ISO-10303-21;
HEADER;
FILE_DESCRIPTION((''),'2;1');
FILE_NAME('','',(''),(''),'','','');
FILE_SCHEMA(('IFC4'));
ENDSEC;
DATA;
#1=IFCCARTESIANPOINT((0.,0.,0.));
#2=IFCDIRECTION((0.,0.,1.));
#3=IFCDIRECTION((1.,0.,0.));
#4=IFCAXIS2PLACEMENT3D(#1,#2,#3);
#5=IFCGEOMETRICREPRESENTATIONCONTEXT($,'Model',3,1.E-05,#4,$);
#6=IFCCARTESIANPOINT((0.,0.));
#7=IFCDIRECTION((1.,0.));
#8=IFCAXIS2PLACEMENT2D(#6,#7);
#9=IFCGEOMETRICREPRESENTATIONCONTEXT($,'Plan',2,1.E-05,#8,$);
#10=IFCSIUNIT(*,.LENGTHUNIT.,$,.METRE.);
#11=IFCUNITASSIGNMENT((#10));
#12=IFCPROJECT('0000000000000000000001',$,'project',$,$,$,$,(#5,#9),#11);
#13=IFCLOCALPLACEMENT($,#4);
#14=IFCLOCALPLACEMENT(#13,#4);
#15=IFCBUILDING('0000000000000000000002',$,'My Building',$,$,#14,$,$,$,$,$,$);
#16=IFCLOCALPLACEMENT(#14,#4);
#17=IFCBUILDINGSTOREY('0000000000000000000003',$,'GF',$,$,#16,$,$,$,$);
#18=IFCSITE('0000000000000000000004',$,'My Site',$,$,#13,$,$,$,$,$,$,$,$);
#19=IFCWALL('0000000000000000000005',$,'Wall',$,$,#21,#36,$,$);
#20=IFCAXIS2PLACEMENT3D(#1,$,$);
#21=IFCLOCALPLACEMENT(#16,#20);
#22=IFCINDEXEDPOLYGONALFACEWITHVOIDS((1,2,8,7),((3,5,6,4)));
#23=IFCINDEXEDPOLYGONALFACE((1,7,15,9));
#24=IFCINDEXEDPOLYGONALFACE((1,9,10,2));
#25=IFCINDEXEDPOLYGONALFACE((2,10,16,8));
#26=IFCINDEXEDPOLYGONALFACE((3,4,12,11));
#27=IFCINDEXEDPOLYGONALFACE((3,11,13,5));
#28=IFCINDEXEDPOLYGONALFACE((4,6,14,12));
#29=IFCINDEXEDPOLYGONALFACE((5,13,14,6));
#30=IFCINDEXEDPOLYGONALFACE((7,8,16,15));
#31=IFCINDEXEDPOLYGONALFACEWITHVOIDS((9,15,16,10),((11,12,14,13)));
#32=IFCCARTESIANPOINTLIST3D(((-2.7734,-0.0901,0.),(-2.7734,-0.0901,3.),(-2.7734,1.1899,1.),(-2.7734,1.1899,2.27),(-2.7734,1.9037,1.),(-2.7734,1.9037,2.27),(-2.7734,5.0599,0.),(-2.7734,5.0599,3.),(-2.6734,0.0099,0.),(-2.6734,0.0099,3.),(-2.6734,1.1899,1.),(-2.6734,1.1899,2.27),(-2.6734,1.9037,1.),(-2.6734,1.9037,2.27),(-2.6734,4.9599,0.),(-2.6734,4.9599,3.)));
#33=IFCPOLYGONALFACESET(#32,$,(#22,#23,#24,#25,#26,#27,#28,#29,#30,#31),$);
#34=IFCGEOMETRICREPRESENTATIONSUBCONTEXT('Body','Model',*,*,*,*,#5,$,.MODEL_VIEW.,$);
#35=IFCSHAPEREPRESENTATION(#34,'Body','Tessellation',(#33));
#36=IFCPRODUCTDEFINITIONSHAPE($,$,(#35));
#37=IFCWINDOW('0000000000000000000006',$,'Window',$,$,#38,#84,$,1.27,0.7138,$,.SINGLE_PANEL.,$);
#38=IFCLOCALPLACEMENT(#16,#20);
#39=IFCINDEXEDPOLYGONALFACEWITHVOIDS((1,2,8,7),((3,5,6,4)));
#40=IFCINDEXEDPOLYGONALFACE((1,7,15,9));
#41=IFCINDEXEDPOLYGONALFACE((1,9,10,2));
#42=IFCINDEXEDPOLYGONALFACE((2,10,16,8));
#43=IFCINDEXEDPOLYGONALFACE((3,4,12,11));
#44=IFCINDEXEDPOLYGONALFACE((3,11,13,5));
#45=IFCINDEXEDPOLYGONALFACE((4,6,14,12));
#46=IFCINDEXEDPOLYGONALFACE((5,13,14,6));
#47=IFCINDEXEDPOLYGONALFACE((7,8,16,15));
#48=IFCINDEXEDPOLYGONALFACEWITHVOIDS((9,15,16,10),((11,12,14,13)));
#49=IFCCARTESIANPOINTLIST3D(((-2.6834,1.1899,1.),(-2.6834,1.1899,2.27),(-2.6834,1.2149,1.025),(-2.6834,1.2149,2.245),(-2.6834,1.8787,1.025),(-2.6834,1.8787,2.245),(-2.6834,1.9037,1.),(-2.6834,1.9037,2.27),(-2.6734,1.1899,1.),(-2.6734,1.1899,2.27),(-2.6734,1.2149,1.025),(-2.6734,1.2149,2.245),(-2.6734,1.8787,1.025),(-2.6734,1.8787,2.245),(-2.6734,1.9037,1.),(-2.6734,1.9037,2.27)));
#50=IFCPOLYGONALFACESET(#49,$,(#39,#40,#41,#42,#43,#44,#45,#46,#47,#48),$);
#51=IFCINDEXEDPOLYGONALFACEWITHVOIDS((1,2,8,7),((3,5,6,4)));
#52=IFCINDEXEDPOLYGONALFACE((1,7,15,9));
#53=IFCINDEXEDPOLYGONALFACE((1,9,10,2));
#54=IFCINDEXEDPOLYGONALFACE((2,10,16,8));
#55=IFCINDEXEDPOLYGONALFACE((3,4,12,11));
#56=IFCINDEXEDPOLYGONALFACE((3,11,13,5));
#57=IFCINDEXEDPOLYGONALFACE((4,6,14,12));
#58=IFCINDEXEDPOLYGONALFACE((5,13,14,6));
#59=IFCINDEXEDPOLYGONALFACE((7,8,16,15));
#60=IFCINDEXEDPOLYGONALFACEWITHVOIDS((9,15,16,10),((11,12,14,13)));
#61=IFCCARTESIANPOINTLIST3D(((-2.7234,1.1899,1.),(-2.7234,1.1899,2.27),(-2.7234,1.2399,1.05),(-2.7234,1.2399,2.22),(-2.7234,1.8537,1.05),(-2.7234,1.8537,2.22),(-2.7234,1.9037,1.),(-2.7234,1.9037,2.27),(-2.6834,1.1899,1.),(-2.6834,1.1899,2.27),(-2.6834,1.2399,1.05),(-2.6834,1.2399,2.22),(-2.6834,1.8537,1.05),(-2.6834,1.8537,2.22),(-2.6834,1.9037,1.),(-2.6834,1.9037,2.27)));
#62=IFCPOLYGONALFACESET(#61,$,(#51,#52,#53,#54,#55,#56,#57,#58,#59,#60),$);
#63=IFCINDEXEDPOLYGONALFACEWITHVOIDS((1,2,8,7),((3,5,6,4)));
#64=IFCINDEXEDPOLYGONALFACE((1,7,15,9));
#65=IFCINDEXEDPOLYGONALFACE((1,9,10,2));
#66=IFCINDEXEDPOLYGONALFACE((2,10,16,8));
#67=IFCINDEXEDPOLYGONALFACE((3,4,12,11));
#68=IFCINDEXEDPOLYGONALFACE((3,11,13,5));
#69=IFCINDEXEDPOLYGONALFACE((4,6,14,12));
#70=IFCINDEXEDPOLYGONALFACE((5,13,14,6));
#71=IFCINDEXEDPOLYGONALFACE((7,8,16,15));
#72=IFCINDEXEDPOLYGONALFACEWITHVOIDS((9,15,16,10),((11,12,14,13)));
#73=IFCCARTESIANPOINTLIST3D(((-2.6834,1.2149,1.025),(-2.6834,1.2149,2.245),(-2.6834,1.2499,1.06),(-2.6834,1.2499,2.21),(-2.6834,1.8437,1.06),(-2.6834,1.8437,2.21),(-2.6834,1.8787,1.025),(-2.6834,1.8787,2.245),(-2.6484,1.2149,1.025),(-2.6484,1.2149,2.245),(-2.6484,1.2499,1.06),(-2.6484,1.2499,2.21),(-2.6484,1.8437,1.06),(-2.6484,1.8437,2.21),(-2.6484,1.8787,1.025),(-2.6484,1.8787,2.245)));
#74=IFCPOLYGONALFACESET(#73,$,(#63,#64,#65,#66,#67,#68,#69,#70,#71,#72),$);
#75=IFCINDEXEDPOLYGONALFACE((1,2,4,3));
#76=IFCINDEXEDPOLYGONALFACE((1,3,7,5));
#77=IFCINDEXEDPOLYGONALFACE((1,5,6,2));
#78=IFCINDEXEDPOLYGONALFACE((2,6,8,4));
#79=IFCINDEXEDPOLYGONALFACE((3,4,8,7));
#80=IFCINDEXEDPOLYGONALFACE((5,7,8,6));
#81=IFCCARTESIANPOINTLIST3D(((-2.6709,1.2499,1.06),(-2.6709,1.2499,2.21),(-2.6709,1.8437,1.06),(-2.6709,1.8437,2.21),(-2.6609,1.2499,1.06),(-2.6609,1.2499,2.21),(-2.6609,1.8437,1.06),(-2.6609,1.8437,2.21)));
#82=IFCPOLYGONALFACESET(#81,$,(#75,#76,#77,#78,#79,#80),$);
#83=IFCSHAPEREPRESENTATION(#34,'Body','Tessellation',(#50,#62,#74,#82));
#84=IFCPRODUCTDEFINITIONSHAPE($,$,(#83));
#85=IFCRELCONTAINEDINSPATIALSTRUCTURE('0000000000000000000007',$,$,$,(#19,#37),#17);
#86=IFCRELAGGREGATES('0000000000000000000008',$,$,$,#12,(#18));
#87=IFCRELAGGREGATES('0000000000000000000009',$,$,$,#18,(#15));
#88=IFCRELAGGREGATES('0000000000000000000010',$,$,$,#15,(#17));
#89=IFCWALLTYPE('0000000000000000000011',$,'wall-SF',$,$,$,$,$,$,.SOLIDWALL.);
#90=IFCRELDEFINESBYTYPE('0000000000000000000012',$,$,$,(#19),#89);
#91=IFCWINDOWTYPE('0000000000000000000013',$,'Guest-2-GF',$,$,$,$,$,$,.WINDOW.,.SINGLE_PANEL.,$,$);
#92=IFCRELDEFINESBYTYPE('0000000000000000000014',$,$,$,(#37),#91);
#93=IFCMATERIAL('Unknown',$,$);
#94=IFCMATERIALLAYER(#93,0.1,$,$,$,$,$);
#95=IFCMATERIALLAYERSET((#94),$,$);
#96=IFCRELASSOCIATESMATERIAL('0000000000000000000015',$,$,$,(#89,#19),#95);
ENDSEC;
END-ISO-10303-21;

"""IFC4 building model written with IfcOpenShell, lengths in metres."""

from ifc_helpers import new_model, entity, si_unit, frame, origin_with_axes, origin_2d_with_axis, place, context, subcontext, project, spatial, line, indexed_curve, outline, extrude, shape, source, transform, mapped, material, layer, layer_set, layer_usage, type_object, type_shapes, element, fill, save


model = new_model("IFC4")

# Units and contexts
model_context = context("Model", 3, precision=1e-05, world=origin_with_axes())
plan_context = context("Plan", 2, precision=1e-05, world=origin_2d_with_axis())
body_context_1 = subcontext(model_context, "Body", "Model", "MODEL_VIEW")
body_context_2 = subcontext(plan_context, "Body", "Plan", "PLAN_VIEW")
ifc_project = project(units=[si_unit("LENGTHUNIT", "METRE")], contexts=[model_context, plan_context])

# Site, building, storey
site_placement = place(None, origin_with_axes())
site = spatial("IfcSite", under=ifc_project, at=site_placement, Name="My Site")
building_placement = place(site_placement, origin_with_axes())
building = spatial("IfcBuilding", under=site, at=building_placement, Name="My Building")
storey_placement = place(building_placement, origin_with_axes())
storey = spatial("IfcBuildingStorey", under=building, at=storey_placement, Name="GF")

# Shared definitions
ifc_material = material(Name="Unknown")

# Shared definitions
ifc_layer_1 = layer(ifc_material, 0.1)
ifc_layer_set_1 = layer_set([ifc_layer_1])
wall_type = type_object("IfcWallType", Name="wall-SF", PredefinedType="SOLIDWALL", material=ifc_layer_set_1)

# Wall, opening, window
ifc_layer_usage_1 = layer_usage(ifc_layer_set_1, "AXIS2", "POSITIVE", 0.0)
wall_1_placement = place(storey_placement, frame((-2.7734, 5.0599, 0.0), z_axis=(0.0, 0.0, 1.0), x_axis=(0.0, -1.0, 0.0)))
wall_1 = element("IfcWall", 1, at=wall_1_placement, inside=storey, type_object=wall_type, material=ifc_layer_usage_1, Name="Wall", context=body_context_1, shape_type="SweptSolid", body=[
    extrude(outline(indexed_curve([(0.0, 0.0), (0.1, 0.1), (5.05, 0.1), (5.15, 0.0)], segments=[line(1, 2, 3, 4, 1)])), origin_with_axes(), (0.0, 0.0, 1.0), 3.0),
])
shared_shape_1 = source(origin_with_axes(), body_context_1, "Body", "SweptSolid", [
    extrude(outline(indexed_curve([(0.0, 0.0), (0.7138, 0.0), (0.7138, 1.27), (0.0, 1.27)], segments=[line(1, 2, 3, 4, 1)])), frame((0.0, -0.6, 0.0), z_axis=(0.0, -1.0, 0.0), x_axis=(1.0, 0.0, 0.0)), (0.0, 0.0, -1.0), 1.2),
])
opening_1_placement = place(wall_1_placement, frame((3.1562, 0.0, 1.0), z_axis=(0.0, 0.0, 1.0), x_axis=(1.0, 0.0, 0.0)))
opening_1 = element("IfcOpeningElement", 2, at=opening_1_placement, cuts=wall_1, PredefinedType="OPENING", context=body_context_1, shape_type="MappedRepresentation", body=[
    mapped(shared_shape_1, transform((0.0, 0.0, 0.0), x_axis=(1.0, 0.0, 0.0), y_axis=(0.0, 1.0, 0.0), z_axis=(0.0, 0.0, 1.0), scale=1.0)),
])
window_type_1 = type_object("IfcWindowType", Name="Guest-2-GF", PartitioningType="SINGLE_PANEL", PredefinedType="WINDOW")
shared_shape_2 = source(origin_with_axes(), body_context_1, "Body", "SweptSolid", [
    extrude(outline(indexed_curve([(0.0, 0.0), (0.7138, 0.0), (0.7138, 1.27), (0.0, 1.27)], segments=[line(1, 2, 3, 4, 1)]), holes=[indexed_curve([(0.025, 0.025), (0.6888, 0.025), (0.6888, 1.245), (0.025, 1.245)], segments=[line(1, 2, 3, 4, 1)])]), frame((0.0, 0.09, 0.0), z_axis=(0.0, -1.0, 0.0), x_axis=(1.0, 0.0, 0.0)), (0.0, 0.0, -1.0), 0.01),
    extrude(outline(indexed_curve([(0.0, 0.0), (0.7138, 0.0), (0.7138, 1.27), (0.0, 1.27)], segments=[line(1, 2, 3, 4, 1)]), holes=[indexed_curve([(0.05, 0.05), (0.6638, 0.05), (0.6638, 1.22), (0.05, 1.22)], segments=[line(1, 2, 3, 4, 1)])]), frame((0.0, 0.05, 0.0), z_axis=(0.0, -1.0, 0.0), x_axis=(1.0, 0.0, 0.0)), (0.0, 0.0, -1.0), 0.04),
    extrude(outline(indexed_curve([(0.0, 0.0), (0.6638, 0.0), (0.6638, 1.22), (0.0, 1.22)], segments=[line(1, 2, 3, 4, 1)]), holes=[indexed_curve([(0.035, 0.035), (0.6288, 0.035), (0.6288, 1.185), (0.035, 1.185)], segments=[line(1, 2, 3, 4, 1)])]), frame((0.025, 0.09, 0.025), z_axis=(0.0, -1.0, 0.0), x_axis=(1.0, 0.0, 0.0)), (0.0, 0.0, -1.0), 0.035),
    extrude(outline(indexed_curve([(0.035, 0.035), (0.6288, 0.035), (0.6288, 1.185), (0.035, 1.185)], segments=[line(1, 2, 3, 4, 1)])), frame((0.025, 0.1025, 0.025), z_axis=(0.0, -1.0, 0.0), x_axis=(1.0, 0.0, 0.0)), (0.0, 0.0, -1.0), 0.01),
])
shared_shape_3 = source(origin_with_axes(), body_context_2, "Body", "Curve2D", [
    entity("IfcIndexedPolyCurve", entity("IfcCartesianPointList2D", [[0.05, 0.05], [0.6638, 0.05]])),
    entity("IfcIndexedPolyCurve", entity("IfcCartesianPointList2D", [[0.0, 0.1], [0.025, 0.1], [0.025, 0.09], [0.05, 0.09], [0.05, 0.05], [0.0, 0.05]]), [entity("IfcLineIndex", [1, 2, 3, 4, 5, 6, 1])]),
    entity("IfcIndexedPolyCurve", entity("IfcCartesianPointList2D", [[0.7138, 0.1], [0.6888, 0.1], [0.6888, 0.09], [0.6638, 0.09], [0.6638, 0.05], [0.7138, 0.05]]), [entity("IfcLineIndex", [1, 2, 3, 4, 5, 6, 1])]),
    entity("IfcIndexedPolyCurve", entity("IfcCartesianPointList2D", [[0.025, 0.09], [0.06, 0.09], [0.06, 0.125], [0.025, 0.125]]), [entity("IfcLineIndex", [1, 2, 3, 4, 1])]),
    entity("IfcIndexedPolyCurve", entity("IfcCartesianPointList2D", [[0.6888, 0.09], [0.6538, 0.09], [0.6538, 0.125], [0.6888, 0.125]]), [entity("IfcLineIndex", [1, 2, 3, 4, 1])]),
    entity("IfcIndexedPolyCurve", entity("IfcCartesianPointList2D", [[0.06, 0.09], [0.6538, 0.09]])),
    entity("IfcIndexedPolyCurve", entity("IfcCartesianPointList2D", [[0.06, 0.125], [0.6538, 0.125]])),
    entity("IfcIndexedPolyCurve", entity("IfcCartesianPointList2D", [[0.06, 0.1075], [0.6538, 0.1075]])),
])
type_shapes(window_type_1, [shared_shape_2, shared_shape_3])
window_1_placement = place(opening_1_placement, frame((0.0, 0.0, 0.0), z_axis=(0.0, 0.0, 1.0), x_axis=(1.0, 0.0, 0.0)))
window_1 = element("IfcWindow", 3, at=window_1_placement, inside=storey, type_object=window_type_1, Name="Window", OverallHeight=1.27, OverallWidth=0.7138, PartitioningType="SINGLE_PANEL", shapes=[
    shape(body_context_1, "Body", "MappedRepresentation", [mapped(shared_shape_2, transform((0.0, 0.0, 0.0), x_axis=(1.0, 0.0, 0.0), y_axis=(0.0, 1.0, 0.0), z_axis=(0.0, 0.0, 1.0), scale=1.0))]),
    shape(body_context_2, "Body", "MappedRepresentation", [mapped(shared_shape_3, transform((0.0, 0.0, 0.0), x_axis=(1.0, 0.0, 0.0), y_axis=(0.0, 1.0, 0.0), z_axis=(0.0, 0.0, 1.0), scale=1.0))]),
])
fill(opening_1, window_1)

save(model, "model.ifc")
